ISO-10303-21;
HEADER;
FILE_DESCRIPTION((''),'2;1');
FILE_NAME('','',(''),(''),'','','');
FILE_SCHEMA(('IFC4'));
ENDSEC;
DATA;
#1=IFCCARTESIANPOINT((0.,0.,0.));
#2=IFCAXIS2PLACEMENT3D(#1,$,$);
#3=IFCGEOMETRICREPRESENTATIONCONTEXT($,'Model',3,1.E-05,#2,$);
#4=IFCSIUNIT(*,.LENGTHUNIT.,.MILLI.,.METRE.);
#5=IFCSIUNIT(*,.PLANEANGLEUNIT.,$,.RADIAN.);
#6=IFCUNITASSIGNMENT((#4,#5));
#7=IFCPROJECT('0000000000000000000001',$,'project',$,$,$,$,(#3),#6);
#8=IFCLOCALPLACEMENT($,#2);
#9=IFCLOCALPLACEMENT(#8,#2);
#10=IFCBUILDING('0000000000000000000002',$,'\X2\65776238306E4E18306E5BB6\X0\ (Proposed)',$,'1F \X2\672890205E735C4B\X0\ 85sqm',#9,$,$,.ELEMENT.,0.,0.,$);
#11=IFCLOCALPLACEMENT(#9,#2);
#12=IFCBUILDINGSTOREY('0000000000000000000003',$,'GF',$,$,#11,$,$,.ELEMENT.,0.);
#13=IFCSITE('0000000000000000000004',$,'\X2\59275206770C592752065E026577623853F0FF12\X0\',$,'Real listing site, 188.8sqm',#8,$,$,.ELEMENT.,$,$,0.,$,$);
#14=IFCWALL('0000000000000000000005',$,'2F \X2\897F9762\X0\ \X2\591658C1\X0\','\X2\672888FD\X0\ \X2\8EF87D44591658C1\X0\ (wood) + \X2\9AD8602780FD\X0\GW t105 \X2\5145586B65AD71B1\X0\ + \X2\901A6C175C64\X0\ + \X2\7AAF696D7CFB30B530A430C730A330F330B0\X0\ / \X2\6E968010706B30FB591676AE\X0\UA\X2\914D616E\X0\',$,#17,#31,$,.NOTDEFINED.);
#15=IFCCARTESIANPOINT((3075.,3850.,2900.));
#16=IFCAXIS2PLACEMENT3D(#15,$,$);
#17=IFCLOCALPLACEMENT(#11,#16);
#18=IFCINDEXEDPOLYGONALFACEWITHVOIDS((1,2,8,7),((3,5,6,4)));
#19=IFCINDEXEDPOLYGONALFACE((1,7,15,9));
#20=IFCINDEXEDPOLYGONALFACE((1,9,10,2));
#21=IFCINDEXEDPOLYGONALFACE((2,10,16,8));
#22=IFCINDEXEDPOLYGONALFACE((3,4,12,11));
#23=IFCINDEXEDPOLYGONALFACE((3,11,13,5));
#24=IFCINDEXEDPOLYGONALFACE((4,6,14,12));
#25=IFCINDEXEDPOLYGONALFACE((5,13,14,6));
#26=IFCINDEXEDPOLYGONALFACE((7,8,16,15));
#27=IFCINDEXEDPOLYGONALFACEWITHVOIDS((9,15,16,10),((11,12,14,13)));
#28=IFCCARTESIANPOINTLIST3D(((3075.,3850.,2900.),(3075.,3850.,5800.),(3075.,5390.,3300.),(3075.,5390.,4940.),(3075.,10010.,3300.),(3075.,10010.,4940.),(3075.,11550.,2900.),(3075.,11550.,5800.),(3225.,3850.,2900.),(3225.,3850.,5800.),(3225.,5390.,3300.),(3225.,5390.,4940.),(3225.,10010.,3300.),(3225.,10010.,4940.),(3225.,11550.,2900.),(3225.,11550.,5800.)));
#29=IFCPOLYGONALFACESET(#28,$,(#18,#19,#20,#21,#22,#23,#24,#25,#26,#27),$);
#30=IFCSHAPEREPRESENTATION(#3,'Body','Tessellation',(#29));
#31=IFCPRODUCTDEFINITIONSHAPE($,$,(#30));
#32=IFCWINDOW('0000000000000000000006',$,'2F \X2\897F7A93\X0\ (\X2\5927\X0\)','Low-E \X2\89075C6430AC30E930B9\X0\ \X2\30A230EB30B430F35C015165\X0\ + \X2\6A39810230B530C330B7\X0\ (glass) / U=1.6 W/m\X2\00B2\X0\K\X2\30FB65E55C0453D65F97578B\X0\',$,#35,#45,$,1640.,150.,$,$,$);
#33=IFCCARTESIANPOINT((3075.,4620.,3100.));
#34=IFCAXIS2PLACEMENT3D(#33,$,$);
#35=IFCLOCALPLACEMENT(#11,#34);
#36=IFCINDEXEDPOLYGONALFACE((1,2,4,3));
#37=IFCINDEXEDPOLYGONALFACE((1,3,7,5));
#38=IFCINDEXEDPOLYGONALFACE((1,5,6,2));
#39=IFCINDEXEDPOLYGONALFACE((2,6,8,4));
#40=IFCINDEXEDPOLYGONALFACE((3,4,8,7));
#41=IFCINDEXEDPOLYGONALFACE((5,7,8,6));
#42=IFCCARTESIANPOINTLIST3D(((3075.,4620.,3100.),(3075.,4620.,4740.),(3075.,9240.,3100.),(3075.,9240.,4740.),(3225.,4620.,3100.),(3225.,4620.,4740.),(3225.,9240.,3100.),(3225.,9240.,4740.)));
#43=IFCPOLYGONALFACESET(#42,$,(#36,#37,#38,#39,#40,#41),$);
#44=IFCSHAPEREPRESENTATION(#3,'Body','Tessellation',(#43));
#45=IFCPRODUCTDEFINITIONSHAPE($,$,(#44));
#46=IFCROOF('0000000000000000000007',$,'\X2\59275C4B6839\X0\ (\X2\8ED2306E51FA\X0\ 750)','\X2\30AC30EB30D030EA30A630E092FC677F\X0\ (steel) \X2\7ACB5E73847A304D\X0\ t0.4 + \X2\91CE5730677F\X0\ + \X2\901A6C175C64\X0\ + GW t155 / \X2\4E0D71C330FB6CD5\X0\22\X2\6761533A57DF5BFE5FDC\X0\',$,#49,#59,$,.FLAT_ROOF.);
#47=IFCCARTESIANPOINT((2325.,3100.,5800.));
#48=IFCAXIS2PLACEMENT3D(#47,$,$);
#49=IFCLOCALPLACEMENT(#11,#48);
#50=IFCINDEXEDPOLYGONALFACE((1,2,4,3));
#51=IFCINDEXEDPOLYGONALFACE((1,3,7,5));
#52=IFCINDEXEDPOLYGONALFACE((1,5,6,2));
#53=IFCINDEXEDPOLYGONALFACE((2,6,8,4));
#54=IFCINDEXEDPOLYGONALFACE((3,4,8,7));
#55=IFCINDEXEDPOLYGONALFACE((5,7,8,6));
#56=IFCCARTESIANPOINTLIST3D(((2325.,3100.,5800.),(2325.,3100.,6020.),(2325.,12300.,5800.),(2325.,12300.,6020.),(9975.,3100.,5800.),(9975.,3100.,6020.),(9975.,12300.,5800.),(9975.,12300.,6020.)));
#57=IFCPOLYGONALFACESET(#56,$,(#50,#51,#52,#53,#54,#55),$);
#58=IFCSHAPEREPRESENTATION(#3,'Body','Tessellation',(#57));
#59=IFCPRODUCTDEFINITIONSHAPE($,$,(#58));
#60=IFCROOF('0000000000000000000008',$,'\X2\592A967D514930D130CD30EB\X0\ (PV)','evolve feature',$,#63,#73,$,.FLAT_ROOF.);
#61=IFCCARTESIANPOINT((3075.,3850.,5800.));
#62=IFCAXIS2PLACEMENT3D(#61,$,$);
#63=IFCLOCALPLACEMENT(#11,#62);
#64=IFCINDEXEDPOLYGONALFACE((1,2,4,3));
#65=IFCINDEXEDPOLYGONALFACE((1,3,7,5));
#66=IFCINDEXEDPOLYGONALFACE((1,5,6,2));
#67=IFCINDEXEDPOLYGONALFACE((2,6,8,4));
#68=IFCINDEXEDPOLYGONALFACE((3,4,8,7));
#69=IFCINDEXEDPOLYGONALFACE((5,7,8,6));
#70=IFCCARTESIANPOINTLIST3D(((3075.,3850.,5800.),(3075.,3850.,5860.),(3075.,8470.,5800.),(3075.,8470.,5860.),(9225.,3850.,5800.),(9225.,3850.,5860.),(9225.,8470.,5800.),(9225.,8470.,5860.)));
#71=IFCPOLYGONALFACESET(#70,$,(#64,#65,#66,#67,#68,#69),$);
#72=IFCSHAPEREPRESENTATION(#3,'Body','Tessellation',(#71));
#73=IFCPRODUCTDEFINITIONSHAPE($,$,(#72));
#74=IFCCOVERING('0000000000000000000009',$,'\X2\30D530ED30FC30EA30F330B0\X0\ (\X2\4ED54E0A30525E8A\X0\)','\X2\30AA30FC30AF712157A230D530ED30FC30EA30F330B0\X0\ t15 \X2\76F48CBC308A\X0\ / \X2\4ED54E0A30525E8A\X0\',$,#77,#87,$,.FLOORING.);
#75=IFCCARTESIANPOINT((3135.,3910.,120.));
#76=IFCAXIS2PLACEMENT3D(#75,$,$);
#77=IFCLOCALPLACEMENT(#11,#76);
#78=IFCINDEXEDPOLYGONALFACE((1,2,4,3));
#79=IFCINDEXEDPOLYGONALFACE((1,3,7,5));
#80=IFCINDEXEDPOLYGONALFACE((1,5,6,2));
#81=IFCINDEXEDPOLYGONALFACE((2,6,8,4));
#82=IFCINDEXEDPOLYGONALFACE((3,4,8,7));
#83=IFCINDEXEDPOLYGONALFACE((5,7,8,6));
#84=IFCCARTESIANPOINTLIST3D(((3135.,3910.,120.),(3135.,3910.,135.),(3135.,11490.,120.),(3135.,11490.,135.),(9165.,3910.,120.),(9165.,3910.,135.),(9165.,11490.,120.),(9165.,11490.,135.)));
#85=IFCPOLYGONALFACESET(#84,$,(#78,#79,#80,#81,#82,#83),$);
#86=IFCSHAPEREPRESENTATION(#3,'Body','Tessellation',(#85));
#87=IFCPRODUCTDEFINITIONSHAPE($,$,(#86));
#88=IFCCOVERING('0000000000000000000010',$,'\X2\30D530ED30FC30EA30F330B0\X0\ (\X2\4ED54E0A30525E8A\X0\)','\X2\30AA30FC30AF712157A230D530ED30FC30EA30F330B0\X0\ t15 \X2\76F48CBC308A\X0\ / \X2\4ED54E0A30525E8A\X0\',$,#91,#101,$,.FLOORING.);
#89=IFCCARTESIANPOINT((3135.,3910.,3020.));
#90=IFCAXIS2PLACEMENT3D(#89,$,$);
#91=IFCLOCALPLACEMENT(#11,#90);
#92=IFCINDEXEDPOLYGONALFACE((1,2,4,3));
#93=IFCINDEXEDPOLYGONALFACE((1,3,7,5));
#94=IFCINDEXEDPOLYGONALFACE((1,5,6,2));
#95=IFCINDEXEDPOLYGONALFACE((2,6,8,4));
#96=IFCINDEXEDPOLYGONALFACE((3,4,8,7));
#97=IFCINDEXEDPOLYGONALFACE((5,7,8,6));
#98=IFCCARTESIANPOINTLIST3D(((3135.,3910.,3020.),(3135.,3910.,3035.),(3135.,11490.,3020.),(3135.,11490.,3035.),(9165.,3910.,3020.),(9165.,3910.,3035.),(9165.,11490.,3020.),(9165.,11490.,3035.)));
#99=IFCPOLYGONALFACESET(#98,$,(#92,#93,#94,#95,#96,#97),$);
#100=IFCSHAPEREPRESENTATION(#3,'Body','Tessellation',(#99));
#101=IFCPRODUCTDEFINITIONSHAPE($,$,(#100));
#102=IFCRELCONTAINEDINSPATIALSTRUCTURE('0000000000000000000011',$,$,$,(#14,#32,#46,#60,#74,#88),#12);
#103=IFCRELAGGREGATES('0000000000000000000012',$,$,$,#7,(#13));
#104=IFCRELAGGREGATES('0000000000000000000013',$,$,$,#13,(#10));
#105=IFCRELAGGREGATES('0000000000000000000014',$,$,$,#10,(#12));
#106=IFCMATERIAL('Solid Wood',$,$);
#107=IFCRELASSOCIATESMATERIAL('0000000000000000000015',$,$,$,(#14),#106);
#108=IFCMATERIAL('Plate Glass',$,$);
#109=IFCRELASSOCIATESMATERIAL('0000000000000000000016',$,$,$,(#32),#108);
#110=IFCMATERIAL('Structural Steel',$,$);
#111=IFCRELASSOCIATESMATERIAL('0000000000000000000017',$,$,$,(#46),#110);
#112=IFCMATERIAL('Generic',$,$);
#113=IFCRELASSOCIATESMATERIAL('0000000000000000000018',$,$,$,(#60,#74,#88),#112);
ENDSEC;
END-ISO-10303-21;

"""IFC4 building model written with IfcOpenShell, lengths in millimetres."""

from ifc_helpers import new_model, si_unit, frame, frame_2d, origin, place, context, project, spatial, rectangle, extrude, material, element, fill, save


model = new_model("IFC4")

# Units and contexts
model_context = context("Model", 3, precision=1e-05, world=origin())
ifc_project = project(units=[si_unit("LENGTHUNIT", "METRE", prefix="MILLI"), si_unit("PLANEANGLEUNIT", "RADIAN")], contexts=[model_context])

# Site, building, storey
site_placement = place(None, origin())
site = spatial("IfcSite", under=ifc_project, at=site_placement, Name="大分県大分市敷戸台２", ObjectType="Real listing site, 188.8sqm", CompositionType="ELEMENT", RefElevation=0.0)
building_placement = place(site_placement, origin())
building = spatial("IfcBuilding", under=site, at=building_placement, Name="敷戸の丘の家 (Proposed)", ObjectType="1F 木造平屋 85sqm", CompositionType="ELEMENT", ElevationOfRefHeight=0.0, ElevationOfTerrain=0.0)
storey_placement = place(building_placement, origin())
storey = spatial("IfcBuildingStorey", under=building, at=storey_placement, Name="GF", CompositionType="ELEMENT", Elevation=0.0)

# Shared definitions
ifc_material_1 = material(Name="Solid Wood")
ifc_material_2 = material(Name="Generic")

# Shared definitions
ifc_material_3 = material(Name="Plate Glass")

# Wall, opening, window
wall_1_placement = place(storey_placement, frame((3075.0, 3850.0, 2900.0)))
wall_1 = element("IfcWall", 1, at=wall_1_placement, inside=storey, material=ifc_material_1, Name="2F 西面 外壁", Description="木製 軸組外壁 (wood) + 高性能GW t105 充填断熱 + 通気層 + 窯業系サイディング / 準耐火・外皮UA配慮", PredefinedType="NOTDEFINED", context=model_context, shape_type="SweptSolid", body=[
    extrude(rectangle(XDim=150.0, YDim=7700.0, at=frame_2d((75.0, 3850.0))), frame((3075.0, 3850.0, 2900.0)), (0.0, 0.0, 1.0), 2900.0),
])
opening_1_placement = place(storey_placement, frame((3075.0, 4620.0, 3100.0)))
opening_1 = element("IfcOpeningElement", 2, at=opening_1_placement, cuts=wall_1, PredefinedType="NOTDEFINED", context=model_context, shape_type="SweptSolid", body=[
    extrude(rectangle(XDim=150.0, YDim=4620.0, at=frame_2d((75.0, 2310.0))), frame((3075.0, 4620.0, 3100.0)), (0.0, 0.0, 1.0), 1640.0),
])
window_1_placement = place(storey_placement, frame((3075.0, 4620.0, 3100.0)))
window_1 = element("IfcWindow", 3, at=window_1_placement, inside=storey, material=ifc_material_3, Name="2F 西窓 (大)", Description="Low-E 複層ガラス アルゴン封入 + 樹脂サッシ (glass) / U=1.6 W/m²K・日射取得型", OverallHeight=1640.0, OverallWidth=150.0, context=model_context, shape_type="SweptSolid", body=[
    extrude(rectangle(XDim=150.0, YDim=4620.0, at=frame_2d((75.0, 2310.0))), frame((3075.0, 4620.0, 3100.0)), (0.0, 0.0, 1.0), 1640.0),
])
fill(opening_1, window_1)

# Roofs
ifc_material_4 = material(Name="Structural Steel")
roof_1_placement = place(storey_placement, frame((2325.0, 3100.0, 5800.0)))
element("IfcRoof", 4, at=roof_1_placement, inside=storey, material=ifc_material_4, Name="大屋根 (軒の出 750)", Description="ガルバリウム鋼板 (steel) 立平葺き t0.4 + 野地板 + 通気層 + GW t155 / 不燃・法22条区域対応", PredefinedType="FLAT_ROOF", context=model_context, shape_type="SweptSolid", body=[
    extrude(rectangle(XDim=7650.0, YDim=9200.0, at=frame_2d((3825.0, 4600.0))), frame((2325.0, 3100.0, 5800.0)), (0.0, 0.0, 1.0), 220.0),
])
roof_2_placement = place(storey_placement, frame((3075.0, 3850.0, 5800.0)))
element("IfcRoof", 5, at=roof_2_placement, inside=storey, material=ifc_material_2, Name="太陽光パネル (PV)", Description="evolve feature", PredefinedType="FLAT_ROOF", context=model_context, shape_type="SweptSolid", body=[
    extrude(rectangle(XDim=6150.0, YDim=4620.0, at=frame_2d((3075.0, 2310.0))), frame((3075.0, 3850.0, 5800.0)), (0.0, 0.0, 1.0), 60.0),
])

# Coverings
covering_1_placement = place(storey_placement, frame((3135.0, 3910.0, 120.0)))
element("IfcCovering", 6, at=covering_1_placement, inside=storey, material=ifc_material_2, Name="フローリング (仕上げ床)", Description="オーク無垢フローリング t15 直貼り / 仕上げ床", PredefinedType="FLOORING", context=model_context, shape_type="SweptSolid", body=[
    extrude(rectangle(XDim=6030.0, YDim=7580.0, at=frame_2d((3015.0, 3790.0))), frame((3135.0, 3910.0, 120.0)), (0.0, 0.0, 1.0), 15.0),
])
covering_2_placement = place(storey_placement, frame((3135.0, 3910.0, 3020.0)))
element("IfcCovering", 7, at=covering_2_placement, inside=storey, material=ifc_material_2, Name="フローリング (仕上げ床)", Description="オーク無垢フローリング t15 直貼り / 仕上げ床", PredefinedType="FLOORING", context=model_context, shape_type="SweptSolid", body=[
    extrude(rectangle(XDim=6030.0, YDim=7580.0, at=frame_2d((3015.0, 3790.0))), frame((3135.0, 3910.0, 3020.0)), (0.0, 0.0, 1.0), 15.0),
])

save(model, "model.ifc")
